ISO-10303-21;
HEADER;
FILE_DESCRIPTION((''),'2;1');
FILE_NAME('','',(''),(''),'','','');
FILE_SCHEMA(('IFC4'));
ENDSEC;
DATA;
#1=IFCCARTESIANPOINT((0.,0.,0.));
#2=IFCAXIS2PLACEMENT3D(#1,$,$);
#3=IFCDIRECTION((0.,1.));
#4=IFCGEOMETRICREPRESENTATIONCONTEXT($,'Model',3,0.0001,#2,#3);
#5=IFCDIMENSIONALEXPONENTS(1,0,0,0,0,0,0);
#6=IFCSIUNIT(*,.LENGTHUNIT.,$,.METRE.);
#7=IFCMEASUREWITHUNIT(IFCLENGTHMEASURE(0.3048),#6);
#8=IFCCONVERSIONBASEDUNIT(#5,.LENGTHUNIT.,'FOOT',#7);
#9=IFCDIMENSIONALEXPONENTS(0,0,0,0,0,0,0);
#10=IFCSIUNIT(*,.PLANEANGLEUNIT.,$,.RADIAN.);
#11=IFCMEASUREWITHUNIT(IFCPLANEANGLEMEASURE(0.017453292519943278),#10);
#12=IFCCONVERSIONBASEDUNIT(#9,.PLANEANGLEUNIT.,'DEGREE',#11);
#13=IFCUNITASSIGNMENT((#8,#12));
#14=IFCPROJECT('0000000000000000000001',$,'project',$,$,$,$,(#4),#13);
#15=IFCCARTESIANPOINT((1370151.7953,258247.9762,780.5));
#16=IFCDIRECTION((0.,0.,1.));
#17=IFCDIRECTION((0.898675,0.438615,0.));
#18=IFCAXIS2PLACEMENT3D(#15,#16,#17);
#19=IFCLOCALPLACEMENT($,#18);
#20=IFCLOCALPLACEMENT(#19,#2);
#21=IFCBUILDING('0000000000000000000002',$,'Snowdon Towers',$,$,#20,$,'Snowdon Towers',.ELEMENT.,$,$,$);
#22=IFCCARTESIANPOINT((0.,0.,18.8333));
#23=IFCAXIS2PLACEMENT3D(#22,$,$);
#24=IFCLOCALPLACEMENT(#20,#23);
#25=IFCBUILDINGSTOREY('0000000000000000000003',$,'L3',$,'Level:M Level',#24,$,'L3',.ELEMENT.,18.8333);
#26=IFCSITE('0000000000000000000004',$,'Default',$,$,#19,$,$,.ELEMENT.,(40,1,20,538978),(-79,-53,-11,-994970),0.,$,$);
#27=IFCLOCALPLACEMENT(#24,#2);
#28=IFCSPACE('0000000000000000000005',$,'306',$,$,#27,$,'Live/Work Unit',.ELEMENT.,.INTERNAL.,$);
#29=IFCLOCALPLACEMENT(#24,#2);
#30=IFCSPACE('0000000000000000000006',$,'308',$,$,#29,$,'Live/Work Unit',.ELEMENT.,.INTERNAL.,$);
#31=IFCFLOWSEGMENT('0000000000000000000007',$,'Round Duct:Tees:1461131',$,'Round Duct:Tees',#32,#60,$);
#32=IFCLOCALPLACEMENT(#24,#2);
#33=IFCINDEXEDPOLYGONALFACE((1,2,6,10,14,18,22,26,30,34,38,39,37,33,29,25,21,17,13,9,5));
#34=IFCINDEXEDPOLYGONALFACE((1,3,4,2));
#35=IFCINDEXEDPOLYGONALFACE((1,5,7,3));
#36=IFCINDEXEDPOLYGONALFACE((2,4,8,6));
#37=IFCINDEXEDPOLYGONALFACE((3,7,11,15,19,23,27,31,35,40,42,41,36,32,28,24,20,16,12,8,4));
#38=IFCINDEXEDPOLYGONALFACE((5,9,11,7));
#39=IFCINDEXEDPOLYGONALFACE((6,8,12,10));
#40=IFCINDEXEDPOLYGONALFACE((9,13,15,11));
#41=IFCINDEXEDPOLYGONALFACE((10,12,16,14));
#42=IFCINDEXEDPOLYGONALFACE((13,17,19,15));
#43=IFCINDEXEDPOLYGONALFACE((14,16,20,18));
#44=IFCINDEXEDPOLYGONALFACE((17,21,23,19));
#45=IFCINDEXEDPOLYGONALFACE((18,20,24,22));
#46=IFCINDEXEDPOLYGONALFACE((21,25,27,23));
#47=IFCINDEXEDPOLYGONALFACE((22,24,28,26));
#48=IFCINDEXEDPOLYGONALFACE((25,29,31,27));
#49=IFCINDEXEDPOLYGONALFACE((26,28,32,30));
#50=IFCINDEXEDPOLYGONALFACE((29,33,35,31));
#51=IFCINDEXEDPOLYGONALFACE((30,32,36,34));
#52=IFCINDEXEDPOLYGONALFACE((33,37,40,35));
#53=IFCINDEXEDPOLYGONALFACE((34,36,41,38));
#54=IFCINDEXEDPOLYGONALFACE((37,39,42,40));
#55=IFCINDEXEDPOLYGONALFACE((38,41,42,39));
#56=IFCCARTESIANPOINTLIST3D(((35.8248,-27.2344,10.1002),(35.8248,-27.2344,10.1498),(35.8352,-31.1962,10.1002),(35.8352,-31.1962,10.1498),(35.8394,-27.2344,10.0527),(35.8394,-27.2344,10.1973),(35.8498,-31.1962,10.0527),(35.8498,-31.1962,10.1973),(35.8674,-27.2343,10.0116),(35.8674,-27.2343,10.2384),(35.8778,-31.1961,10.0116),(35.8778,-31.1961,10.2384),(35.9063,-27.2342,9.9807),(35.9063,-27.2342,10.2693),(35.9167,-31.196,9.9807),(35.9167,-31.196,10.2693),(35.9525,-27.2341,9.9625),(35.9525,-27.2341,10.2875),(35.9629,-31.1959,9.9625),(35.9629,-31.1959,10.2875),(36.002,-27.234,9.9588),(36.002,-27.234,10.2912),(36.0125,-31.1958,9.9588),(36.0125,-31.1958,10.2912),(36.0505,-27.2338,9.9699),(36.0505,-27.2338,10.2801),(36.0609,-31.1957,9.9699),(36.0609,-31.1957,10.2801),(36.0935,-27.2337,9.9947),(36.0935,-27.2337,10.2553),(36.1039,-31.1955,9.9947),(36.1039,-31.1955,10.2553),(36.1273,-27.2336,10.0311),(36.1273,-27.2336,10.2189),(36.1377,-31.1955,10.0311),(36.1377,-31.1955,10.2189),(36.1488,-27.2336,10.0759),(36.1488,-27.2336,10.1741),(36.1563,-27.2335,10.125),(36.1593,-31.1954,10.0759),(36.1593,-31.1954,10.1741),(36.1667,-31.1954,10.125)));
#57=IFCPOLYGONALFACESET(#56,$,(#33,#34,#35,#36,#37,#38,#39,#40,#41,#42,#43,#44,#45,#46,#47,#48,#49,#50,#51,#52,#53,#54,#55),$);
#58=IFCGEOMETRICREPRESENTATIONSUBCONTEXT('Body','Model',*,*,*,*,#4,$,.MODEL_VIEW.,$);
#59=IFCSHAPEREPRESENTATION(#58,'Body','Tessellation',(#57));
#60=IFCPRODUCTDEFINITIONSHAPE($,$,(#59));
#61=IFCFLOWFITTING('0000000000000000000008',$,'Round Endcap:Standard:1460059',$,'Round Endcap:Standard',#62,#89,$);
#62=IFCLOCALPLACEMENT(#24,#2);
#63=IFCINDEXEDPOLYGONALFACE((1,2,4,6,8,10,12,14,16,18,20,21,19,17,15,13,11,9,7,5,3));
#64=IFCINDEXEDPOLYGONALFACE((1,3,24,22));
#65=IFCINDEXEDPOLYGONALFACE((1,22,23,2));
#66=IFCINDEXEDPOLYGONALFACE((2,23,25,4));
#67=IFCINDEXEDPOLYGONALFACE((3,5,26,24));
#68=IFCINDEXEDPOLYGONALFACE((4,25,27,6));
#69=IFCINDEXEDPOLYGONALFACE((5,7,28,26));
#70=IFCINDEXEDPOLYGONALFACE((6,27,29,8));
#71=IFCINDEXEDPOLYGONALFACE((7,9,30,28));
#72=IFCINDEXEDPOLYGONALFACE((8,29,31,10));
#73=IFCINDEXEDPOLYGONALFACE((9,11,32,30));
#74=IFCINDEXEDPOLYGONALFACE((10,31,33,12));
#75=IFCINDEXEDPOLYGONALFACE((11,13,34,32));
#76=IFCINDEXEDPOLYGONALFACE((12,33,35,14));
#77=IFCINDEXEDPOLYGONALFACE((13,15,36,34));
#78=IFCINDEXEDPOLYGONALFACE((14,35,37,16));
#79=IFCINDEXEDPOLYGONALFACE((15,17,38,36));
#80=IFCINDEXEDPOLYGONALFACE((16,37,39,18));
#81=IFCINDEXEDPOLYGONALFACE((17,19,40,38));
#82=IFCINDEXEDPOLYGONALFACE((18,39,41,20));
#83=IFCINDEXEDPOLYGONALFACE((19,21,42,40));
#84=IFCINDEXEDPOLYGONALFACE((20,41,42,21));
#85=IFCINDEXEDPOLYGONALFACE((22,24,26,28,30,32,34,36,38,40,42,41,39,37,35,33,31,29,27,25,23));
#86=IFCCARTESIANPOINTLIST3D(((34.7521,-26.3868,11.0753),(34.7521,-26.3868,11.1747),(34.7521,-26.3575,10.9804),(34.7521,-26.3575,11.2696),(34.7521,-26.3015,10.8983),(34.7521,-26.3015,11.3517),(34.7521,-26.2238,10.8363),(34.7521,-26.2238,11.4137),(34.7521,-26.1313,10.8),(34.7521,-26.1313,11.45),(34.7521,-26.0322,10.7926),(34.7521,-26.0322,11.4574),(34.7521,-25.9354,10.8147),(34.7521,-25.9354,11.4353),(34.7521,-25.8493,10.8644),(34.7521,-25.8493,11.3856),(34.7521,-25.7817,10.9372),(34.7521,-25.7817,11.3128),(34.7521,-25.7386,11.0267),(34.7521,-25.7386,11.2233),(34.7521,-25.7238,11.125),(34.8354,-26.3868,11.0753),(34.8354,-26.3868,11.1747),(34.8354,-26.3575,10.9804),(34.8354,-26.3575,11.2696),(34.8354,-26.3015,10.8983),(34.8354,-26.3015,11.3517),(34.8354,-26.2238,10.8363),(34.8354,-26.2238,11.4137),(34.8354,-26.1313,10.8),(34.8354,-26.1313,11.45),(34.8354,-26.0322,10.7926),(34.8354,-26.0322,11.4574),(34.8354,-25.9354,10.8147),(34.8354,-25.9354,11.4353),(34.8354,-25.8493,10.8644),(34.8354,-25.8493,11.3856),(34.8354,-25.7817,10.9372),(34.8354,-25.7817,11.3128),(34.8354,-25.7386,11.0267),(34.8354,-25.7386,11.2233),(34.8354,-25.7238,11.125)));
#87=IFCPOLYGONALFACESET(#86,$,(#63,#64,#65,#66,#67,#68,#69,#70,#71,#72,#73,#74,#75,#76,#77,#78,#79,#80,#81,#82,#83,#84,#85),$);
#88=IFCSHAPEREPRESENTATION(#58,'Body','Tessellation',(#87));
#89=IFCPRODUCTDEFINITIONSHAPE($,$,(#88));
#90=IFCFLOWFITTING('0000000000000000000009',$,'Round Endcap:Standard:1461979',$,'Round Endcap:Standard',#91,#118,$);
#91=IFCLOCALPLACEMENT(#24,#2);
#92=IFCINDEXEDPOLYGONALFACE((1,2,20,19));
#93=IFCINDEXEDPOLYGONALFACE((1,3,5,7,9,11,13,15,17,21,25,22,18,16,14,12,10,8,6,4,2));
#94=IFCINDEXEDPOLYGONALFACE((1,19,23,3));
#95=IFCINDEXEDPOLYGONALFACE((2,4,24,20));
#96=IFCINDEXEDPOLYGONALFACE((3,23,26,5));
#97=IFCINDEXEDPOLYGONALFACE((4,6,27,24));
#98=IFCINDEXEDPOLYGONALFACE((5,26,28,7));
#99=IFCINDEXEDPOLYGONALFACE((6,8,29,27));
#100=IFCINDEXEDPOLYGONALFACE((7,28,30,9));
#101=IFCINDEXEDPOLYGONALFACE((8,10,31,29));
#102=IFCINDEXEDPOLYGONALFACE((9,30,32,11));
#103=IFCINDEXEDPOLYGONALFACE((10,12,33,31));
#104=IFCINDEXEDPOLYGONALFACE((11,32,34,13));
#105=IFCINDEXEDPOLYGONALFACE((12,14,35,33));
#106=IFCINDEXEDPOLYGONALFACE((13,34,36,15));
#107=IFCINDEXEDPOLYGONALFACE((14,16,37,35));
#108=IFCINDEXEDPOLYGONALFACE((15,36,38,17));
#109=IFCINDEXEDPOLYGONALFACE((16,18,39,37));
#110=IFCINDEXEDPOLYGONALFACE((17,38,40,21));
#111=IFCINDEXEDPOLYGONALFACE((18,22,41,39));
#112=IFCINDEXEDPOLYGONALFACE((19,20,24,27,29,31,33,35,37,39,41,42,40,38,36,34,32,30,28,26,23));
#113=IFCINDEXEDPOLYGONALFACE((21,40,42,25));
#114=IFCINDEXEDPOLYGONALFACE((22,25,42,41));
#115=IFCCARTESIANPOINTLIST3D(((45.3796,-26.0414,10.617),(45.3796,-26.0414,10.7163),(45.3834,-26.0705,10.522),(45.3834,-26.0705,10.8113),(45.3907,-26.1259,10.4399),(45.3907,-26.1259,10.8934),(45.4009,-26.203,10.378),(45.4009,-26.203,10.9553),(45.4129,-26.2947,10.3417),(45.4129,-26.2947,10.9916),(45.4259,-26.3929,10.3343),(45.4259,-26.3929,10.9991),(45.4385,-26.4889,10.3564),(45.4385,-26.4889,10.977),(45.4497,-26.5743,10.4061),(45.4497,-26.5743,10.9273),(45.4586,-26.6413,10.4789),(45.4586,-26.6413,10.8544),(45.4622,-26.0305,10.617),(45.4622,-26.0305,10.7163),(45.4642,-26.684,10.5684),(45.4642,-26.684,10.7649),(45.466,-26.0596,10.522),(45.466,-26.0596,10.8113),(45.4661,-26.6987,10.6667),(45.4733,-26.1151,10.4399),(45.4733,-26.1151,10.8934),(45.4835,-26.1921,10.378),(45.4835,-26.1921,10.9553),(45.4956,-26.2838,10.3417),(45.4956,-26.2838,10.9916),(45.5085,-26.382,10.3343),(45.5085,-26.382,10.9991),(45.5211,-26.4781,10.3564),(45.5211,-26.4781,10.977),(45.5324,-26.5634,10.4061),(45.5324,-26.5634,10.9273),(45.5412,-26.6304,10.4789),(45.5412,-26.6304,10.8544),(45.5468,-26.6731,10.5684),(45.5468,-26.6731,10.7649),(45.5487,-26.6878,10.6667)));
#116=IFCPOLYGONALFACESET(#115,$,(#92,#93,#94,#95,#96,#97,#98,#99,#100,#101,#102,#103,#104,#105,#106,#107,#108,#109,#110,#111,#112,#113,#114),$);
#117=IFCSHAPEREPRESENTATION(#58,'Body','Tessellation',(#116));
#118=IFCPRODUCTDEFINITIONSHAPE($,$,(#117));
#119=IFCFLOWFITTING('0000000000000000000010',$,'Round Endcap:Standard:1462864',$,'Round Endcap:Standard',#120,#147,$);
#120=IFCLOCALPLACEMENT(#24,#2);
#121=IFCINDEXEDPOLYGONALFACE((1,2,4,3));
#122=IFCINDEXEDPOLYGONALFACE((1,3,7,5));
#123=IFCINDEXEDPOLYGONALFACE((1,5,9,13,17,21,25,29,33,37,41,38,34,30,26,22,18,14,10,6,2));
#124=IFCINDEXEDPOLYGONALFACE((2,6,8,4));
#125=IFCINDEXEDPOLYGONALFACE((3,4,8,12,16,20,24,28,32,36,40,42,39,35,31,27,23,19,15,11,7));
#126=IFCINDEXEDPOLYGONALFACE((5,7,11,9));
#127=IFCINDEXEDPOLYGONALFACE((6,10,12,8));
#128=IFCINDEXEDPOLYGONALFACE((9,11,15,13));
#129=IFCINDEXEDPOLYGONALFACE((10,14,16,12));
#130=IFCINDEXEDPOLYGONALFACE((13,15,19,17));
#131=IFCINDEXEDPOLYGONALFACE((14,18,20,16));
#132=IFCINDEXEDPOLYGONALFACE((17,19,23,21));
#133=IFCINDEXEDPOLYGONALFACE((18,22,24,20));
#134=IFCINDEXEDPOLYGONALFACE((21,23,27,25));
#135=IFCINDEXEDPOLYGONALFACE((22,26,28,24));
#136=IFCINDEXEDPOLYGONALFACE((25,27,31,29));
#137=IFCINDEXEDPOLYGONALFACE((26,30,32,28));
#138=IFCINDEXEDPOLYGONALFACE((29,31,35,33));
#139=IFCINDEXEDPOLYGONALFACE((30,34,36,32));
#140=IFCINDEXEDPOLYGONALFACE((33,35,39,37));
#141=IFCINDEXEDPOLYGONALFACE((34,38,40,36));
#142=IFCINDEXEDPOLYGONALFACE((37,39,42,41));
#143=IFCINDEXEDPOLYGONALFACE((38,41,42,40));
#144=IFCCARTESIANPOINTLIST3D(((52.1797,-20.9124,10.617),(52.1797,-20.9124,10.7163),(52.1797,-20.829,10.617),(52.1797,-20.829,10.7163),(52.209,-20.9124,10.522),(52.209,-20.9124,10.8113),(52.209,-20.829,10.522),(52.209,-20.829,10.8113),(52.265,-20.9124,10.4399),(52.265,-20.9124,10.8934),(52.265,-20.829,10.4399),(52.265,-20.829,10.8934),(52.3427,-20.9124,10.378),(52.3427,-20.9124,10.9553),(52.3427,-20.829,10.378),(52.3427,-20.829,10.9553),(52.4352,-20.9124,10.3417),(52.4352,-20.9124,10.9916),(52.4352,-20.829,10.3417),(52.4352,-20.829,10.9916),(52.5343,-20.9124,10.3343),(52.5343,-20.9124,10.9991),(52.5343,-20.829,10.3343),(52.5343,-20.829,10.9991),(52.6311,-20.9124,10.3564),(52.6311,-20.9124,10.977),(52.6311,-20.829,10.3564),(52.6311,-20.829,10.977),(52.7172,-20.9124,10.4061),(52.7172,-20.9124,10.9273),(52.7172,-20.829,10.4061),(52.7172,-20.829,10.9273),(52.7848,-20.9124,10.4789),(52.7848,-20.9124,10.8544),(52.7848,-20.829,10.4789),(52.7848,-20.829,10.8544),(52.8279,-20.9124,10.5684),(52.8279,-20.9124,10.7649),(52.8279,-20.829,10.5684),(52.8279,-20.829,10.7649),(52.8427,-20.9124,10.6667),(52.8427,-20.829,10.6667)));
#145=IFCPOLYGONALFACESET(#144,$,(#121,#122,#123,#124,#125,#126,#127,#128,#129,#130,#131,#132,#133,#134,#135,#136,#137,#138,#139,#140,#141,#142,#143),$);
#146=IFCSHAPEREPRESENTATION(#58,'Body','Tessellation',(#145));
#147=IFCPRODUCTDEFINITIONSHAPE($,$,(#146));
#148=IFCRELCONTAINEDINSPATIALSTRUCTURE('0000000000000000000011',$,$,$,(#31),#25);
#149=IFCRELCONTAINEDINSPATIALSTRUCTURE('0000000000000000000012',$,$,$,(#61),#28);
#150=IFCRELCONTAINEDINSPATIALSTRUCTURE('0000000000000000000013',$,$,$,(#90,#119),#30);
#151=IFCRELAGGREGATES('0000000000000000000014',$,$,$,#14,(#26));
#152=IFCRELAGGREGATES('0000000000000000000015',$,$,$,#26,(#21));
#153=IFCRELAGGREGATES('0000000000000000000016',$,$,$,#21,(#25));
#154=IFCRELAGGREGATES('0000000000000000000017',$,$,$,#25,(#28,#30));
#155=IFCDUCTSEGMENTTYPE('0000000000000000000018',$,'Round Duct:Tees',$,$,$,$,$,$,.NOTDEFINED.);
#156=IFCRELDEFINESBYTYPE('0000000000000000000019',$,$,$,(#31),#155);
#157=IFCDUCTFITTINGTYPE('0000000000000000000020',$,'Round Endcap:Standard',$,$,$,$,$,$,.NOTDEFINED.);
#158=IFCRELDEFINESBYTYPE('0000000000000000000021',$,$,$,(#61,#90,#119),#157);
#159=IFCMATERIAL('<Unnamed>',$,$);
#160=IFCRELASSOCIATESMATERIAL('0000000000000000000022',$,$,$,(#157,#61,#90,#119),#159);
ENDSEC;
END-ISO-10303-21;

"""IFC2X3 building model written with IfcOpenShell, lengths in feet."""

from ifc_helpers import new_model, entity, si_unit, converted_unit, direction, frame, frame_2d, origin, place, context, subcontext, project, spatial, circle, extrude, source, transform, mapped, material, type_object, type_shapes, element, save


model = new_model("IFC2X3")

# Units and contexts
model_context = context("Model", 3, precision=0.0001, world=origin(), true_north=direction((0.0, 1.0)))
body_context = subcontext(model_context, "Body", "Model", "MODEL_VIEW")
ifc_project = project(units=[converted_unit("LENGTHUNIT", "FOOT", entity("IfcLengthMeasure", 0.3048), si_unit("LENGTHUNIT", "METRE"), dimensions=[1, 0, 0, 0, 0, 0, 0]), converted_unit("PLANEANGLEUNIT", "DEGREE", entity("IfcPlaneAngleMeasure", 0.017453292519943278), si_unit("PLANEANGLEUNIT", "RADIAN"), dimensions=[0, 0, 0, 0, 0, 0, 0])], contexts=[model_context])

# Site, building, storey
site_placement = place(None, frame((1370151.7953, 258247.9762, 780.5), z_axis=(0.0, 0.0, 1.0), x_axis=(0.898675, 0.438615, 0.0)))
site = spatial("IfcSite", under=ifc_project, at=site_placement, Name="Default", CompositionType="ELEMENT", RefLatitude=(40, 1, 20, 538978), RefLongitude=(-79, -53, -11, -994970), RefElevation=0.0)
building_placement = place(site_placement, origin())
building = spatial("IfcBuilding", under=site, at=building_placement, Name="Snowdon Towers", LongName="Snowdon Towers", CompositionType="ELEMENT")
storey_placement = place(building_placement, frame((0.0, 0.0, 18.8333)))
storey = spatial("IfcBuildingStorey", under=building, at=storey_placement, Name="L3", ObjectType="Level:M Level", LongName="L3", CompositionType="ELEMENT", Elevation=18.8333)

# Flow segment
duct_segment_type = type_object("IfcDuctSegmentType", Name="Round Duct:Tees", PredefinedType="NOTDEFINED")
flow_segment_1_placement = place(storey_placement, frame((35.8177, -31.1963, 9.9531)))
element("IfcFlowSegment", 1, at=flow_segment_1_placement, inside=storey, type_object=duct_segment_type, Name="Round Duct:Tees:1461131", ObjectType="Round Duct:Tees", context=body_context, shape_type="SweptSolid", body=[
    extrude(circle(Radius=0.1667, at=frame_2d((0.0, 0.0), x_axis=(1.0, 0.0))), frame((0.1823, 0.0004, 0.1719), z_axis=(-0.002628, 0.999997, 0.0), x_axis=(0.999997, 0.002628, 0.0)), (0.0, 0.0, 1.0), 3.9618),
])

# Shared definitions
ifc_material = material(Name="<Unnamed>")

# Shared definitions
space_1_placement = place(storey_placement, origin())
space_1 = spatial("IfcSpace", under=storey, at=space_1_placement, Name="306", LongName="Live/Work Unit", CompositionType="ELEMENT", InteriorOrExteriorSpace="INTERNAL")

# Flow fitting
duct_fitting_type = type_object("IfcDuctFittingType", Name="Round Endcap:Standard", PredefinedType="NOTDEFINED", material=ifc_material)
shared_shape_1 = source(origin(), body_context, "Body", "SweptSolid", [
    extrude(circle(Radius=0.3333, at=frame_2d((0.0, 0.0), x_axis=(1.0, 0.0))), frame((0.0, 0.0, 0.0), z_axis=(1.0, 0.0, 0.0), x_axis=(0.0, 1.0, 0.0)), (0.0, 0.0, 1.0), 0.0833),
])
type_shapes(duct_fitting_type, [shared_shape_1])
flow_fitting_placement = place(space_1_placement, frame((34.7521, -26.0572, 11.125)))
element("IfcFlowFitting", 2, at=flow_fitting_placement, inside=space_1, type_object=duct_fitting_type, material=ifc_material, Name="Round Endcap:Standard:1460059", ObjectType="Round Endcap:Standard", context=body_context, shape_type="MappedRepresentation", body=[
    mapped(shared_shape_1, transform((0.0, 0.0, 0.0), scale=1.0)),
])

# Shared definitions
space_2_placement = place(storey_placement, origin())
space_2 = spatial("IfcSpace", under=storey, at=space_2_placement, Name="308", LongName="Live/Work Unit", CompositionType="ELEMENT", InteriorOrExteriorSpace="INTERNAL")

# Flow fittings
for number, where, z_axis, x_axis, name in (
    (3, (45.5052, -26.3573, 10.6667), (0.0, 0.0, 1.0), (-0.991445, -0.130526, 0.0), "Round Endcap:Standard:1461979"),
    (4, (52.5094, -20.829, 10.6667), (0.0, 0.0, 1.0), (0.0, -1.0, 0.0), "Round Endcap:Standard:1462864"),
):
    element("IfcFlowFitting", number, at=place(space_2_placement, frame(where, z_axis=z_axis, x_axis=x_axis)), inside=space_2, type_object=duct_fitting_type, material=ifc_material, Name=name, ObjectType="Round Endcap:Standard", context=body_context, shape_type="MappedRepresentation", body=[
        mapped(shared_shape_1, transform((0.0, 0.0, 0.0), scale=1.0)),
    ])

save(model, "model.ifc")
